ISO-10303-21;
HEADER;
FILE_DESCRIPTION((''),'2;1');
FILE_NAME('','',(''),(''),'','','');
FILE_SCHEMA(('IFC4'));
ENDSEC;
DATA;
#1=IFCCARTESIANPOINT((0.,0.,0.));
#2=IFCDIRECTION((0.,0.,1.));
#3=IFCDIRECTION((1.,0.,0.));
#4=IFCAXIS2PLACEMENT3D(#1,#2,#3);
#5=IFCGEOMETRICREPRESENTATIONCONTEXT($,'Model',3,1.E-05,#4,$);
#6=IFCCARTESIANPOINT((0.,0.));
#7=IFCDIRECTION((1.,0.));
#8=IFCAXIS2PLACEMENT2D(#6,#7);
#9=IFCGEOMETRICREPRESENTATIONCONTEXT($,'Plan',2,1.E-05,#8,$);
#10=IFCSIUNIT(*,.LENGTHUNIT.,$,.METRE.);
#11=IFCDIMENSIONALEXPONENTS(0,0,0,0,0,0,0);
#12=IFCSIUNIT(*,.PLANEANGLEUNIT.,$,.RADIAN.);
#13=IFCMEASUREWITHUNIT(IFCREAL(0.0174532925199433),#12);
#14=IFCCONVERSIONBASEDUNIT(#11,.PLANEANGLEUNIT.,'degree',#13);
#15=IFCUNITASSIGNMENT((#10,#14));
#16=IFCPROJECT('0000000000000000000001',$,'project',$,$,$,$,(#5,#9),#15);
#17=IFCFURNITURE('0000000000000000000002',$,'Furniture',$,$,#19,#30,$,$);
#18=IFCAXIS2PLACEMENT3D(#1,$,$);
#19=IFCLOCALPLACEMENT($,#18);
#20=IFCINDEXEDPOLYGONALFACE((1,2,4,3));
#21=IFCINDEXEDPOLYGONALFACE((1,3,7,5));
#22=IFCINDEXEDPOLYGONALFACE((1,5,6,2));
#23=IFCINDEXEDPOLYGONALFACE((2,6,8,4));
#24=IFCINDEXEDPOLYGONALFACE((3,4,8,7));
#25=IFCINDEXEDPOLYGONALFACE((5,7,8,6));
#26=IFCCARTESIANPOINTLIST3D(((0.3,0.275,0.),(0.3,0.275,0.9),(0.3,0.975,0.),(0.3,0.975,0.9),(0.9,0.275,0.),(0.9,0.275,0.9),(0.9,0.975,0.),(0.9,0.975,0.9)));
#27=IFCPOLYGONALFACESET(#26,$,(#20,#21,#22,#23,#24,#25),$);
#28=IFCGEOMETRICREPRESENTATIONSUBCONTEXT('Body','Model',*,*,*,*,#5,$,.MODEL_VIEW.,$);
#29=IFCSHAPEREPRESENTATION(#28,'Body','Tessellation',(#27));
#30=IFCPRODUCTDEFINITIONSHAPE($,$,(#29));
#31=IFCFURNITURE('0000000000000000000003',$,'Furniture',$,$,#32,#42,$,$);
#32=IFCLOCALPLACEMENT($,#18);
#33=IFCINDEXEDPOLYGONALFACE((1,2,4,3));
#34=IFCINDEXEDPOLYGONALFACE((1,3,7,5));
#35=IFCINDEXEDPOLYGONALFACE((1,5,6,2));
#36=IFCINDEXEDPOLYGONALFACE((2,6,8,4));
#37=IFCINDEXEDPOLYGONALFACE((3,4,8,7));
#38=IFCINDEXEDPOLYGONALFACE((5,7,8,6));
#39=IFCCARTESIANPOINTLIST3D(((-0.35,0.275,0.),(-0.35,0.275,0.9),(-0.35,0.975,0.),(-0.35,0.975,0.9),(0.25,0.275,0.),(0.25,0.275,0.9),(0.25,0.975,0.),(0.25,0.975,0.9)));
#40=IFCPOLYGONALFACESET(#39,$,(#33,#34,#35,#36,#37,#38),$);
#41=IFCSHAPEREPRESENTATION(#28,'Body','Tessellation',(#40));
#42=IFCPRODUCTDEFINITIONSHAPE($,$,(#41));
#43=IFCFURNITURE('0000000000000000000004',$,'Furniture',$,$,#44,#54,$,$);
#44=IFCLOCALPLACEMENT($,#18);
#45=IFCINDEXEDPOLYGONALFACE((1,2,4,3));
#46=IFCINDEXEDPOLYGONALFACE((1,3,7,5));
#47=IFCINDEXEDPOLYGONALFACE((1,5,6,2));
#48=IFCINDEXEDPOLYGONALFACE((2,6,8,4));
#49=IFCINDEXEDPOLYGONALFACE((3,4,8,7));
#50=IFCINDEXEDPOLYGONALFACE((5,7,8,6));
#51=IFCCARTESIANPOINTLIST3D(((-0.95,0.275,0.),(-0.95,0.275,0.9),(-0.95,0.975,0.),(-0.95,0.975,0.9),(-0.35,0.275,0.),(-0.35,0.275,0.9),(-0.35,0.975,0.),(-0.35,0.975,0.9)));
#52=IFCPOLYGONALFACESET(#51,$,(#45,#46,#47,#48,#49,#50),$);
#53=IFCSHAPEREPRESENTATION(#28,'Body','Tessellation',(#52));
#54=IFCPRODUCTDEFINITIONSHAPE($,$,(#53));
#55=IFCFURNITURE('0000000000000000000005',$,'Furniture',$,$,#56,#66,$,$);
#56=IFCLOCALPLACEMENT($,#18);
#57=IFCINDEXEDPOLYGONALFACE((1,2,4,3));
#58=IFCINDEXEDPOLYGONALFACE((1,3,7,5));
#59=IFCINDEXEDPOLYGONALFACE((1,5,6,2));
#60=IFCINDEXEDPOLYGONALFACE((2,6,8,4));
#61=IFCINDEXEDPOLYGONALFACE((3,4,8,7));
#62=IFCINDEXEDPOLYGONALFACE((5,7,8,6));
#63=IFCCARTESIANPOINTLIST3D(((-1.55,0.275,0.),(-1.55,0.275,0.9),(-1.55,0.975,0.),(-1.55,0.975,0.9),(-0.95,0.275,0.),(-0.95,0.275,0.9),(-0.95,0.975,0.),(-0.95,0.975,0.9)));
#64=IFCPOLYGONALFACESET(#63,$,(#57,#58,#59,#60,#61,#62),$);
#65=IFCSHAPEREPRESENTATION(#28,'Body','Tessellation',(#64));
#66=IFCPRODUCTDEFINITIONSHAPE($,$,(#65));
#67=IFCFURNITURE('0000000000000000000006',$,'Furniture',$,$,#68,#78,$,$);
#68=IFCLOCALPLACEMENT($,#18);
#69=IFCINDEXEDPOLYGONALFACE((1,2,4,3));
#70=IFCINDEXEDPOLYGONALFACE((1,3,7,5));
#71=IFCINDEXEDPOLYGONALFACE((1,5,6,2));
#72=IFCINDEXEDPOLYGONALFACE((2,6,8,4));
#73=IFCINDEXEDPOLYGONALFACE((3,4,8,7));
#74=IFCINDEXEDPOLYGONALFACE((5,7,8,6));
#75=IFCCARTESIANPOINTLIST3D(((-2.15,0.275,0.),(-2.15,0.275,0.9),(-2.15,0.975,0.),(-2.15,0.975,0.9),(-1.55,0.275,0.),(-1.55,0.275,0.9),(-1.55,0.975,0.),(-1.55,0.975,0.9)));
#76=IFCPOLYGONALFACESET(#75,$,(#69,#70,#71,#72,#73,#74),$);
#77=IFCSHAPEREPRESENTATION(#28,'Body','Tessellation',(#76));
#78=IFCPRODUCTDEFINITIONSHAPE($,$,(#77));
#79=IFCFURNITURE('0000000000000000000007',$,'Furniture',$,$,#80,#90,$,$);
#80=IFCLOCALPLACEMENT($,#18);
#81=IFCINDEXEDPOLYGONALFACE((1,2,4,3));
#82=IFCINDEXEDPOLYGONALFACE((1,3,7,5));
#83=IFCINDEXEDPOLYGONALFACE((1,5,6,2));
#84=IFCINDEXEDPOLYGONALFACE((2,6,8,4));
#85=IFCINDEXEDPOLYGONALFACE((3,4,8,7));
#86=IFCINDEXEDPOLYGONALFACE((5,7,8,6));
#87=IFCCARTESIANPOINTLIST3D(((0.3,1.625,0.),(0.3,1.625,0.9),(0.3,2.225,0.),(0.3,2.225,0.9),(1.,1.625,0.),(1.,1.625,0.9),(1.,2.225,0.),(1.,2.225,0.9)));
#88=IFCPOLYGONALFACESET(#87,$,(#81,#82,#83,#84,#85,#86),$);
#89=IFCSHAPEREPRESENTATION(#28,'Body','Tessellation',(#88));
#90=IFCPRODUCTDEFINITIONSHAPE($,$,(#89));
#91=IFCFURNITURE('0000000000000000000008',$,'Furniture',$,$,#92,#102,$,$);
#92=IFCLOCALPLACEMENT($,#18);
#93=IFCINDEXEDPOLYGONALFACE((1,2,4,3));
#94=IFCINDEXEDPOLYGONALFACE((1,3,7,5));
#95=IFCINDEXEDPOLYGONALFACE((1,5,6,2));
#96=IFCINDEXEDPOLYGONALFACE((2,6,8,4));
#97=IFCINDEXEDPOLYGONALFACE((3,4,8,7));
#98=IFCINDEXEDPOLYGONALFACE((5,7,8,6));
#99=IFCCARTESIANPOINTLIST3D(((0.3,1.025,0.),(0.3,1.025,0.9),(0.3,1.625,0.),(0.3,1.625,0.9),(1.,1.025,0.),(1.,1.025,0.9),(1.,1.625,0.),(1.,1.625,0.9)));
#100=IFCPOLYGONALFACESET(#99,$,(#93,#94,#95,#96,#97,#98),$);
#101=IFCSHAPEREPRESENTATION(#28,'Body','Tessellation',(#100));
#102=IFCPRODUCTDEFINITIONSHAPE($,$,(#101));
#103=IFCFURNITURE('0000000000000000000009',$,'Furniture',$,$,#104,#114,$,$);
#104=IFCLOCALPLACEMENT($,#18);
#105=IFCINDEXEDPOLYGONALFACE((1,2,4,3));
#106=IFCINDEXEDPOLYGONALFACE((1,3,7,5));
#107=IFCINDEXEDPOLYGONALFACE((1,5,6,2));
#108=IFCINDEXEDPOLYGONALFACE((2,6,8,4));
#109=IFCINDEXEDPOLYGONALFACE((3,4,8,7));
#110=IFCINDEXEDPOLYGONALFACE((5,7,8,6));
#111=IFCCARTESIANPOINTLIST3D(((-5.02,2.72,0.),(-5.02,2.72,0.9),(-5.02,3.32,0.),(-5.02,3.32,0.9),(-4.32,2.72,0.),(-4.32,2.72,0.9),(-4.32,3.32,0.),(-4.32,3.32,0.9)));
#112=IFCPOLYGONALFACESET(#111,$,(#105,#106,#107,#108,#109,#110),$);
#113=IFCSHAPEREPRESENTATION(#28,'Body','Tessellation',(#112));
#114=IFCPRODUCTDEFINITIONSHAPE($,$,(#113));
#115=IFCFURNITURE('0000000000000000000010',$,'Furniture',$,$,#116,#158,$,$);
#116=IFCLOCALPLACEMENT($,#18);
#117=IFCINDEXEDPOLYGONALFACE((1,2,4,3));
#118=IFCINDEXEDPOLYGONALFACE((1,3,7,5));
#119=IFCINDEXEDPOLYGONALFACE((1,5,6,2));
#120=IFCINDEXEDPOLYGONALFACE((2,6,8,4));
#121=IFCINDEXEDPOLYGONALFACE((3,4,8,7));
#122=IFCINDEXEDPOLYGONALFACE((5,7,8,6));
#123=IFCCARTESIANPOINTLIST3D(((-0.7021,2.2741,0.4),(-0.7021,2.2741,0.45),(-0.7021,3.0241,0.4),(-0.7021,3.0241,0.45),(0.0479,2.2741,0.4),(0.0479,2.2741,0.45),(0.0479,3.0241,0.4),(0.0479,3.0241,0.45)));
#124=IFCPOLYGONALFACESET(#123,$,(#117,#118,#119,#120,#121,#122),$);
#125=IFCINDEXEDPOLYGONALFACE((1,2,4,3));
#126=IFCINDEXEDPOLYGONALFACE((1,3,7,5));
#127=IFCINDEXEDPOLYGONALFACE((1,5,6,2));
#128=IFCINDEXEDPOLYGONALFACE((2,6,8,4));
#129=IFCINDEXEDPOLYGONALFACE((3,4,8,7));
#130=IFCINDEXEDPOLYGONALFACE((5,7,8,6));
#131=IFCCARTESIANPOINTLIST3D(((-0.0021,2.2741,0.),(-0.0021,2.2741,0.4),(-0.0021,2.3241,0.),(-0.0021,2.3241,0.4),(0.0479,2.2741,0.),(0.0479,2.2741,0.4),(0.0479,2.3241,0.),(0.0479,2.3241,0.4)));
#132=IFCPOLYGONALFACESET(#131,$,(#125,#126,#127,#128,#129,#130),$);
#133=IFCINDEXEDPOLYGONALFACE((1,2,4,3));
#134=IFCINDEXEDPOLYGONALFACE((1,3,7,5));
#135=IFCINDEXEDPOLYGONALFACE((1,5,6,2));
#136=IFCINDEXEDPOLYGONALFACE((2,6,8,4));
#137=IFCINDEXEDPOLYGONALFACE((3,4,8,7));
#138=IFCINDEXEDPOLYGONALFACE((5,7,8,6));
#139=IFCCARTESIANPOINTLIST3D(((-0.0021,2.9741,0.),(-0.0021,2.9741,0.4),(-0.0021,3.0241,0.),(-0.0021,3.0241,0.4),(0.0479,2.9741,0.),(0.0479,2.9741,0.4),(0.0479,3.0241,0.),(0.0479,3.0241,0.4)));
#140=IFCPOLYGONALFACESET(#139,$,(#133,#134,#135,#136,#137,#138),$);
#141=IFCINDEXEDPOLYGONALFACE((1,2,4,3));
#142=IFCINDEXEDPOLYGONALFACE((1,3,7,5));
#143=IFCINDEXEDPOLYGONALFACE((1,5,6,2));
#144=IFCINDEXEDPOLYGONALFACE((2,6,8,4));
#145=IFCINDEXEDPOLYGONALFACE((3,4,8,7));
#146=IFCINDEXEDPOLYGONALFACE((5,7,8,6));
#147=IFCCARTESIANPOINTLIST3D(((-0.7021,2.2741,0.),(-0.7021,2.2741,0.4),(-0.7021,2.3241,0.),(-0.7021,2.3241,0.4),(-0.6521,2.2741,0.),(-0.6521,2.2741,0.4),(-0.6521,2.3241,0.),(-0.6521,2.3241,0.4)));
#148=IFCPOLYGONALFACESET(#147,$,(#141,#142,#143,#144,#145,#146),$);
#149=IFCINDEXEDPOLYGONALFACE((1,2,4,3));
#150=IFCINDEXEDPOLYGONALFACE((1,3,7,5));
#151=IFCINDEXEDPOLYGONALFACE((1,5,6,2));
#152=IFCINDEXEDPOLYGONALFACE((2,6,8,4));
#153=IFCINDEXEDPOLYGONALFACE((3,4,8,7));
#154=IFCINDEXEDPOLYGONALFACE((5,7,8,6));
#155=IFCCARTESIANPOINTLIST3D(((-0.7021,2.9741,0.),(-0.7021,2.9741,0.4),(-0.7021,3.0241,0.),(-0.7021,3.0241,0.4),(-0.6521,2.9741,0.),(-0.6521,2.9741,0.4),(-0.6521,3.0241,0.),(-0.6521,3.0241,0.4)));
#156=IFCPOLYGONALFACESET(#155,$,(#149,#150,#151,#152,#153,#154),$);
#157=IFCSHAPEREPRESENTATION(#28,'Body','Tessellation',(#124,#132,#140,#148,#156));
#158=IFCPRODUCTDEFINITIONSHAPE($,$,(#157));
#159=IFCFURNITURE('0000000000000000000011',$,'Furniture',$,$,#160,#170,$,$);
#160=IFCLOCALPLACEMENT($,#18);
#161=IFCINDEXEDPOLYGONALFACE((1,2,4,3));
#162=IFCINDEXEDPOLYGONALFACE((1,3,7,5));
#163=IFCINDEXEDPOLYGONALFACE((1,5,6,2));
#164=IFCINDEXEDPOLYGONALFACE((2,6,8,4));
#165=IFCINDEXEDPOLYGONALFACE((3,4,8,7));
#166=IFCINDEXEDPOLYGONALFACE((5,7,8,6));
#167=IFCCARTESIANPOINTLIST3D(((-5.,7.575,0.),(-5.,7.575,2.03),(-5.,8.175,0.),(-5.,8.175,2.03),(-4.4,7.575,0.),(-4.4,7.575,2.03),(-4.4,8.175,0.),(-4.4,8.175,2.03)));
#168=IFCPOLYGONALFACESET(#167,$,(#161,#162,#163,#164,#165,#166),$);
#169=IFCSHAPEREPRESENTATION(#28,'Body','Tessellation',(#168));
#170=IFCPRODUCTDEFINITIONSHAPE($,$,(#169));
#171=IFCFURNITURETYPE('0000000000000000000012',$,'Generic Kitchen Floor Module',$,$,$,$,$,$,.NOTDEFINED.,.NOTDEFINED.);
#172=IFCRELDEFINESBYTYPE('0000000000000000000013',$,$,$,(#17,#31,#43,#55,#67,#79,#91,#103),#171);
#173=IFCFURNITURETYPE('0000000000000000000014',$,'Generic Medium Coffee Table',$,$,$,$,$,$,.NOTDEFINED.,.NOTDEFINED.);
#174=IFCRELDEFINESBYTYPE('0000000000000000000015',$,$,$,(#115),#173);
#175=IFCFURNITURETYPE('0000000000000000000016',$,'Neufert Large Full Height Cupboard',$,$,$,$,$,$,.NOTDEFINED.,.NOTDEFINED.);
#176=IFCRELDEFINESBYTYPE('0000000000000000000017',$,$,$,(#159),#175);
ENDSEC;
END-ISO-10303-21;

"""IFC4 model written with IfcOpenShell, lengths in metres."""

from ifc_helpers import new_model, entity, si_unit, converted_unit, frame, origin_with_axes, origin_2d_with_axis, place, context, subcontext, project, line, indexed_curve, outline, extrude, shape, source, transform, mapped, type_object, type_shapes, element, save


model = new_model("IFC4")

# Units and contexts
model_context = context("Model", 3, precision=1e-05, world=origin_with_axes())
plan_context = context("Plan", 2, precision=1e-05, world=origin_2d_with_axis())
body_context_1 = subcontext(model_context, "Body", "Model", "MODEL_VIEW")
body_context_2 = subcontext(plan_context, "Body", "Plan", "PLAN_VIEW")
ifc_project = project(units=[si_unit("LENGTHUNIT", "METRE"), converted_unit("PLANEANGLEUNIT", "degree", entity("IfcReal", 0.0174532925199433), si_unit("PLANEANGLEUNIT", "RADIAN"), dimensions=[0, 0, 0, 0, 0, 0, 0])], contexts=[model_context, plan_context])

# Furniture
furniture_type_1 = type_object("IfcFurnitureType", Name="Generic Kitchen Floor Module", AssemblyPlace="NOTDEFINED", PredefinedType="NOTDEFINED")
shared_shape_1 = source(origin_with_axes(), body_context_1, "Body", "SweptSolid", [
    extrude(outline(indexed_curve([(0.0, 0.0), (0.6, 0.0), (0.6, 0.7), (0.0, 0.7)], segments=[line(1, 2, 3, 4, 1)])), origin_with_axes(), (0.0, 0.0, 1.0), 0.9),
])
shared_shape_2 = source(origin_with_axes(), body_context_2, "Body", "Curve2D", [
    entity("IfcIndexedPolyCurve", entity("IfcCartesianPointList2D", [[0.0, 0.0], [0.6, 0.0], [0.6, 0.7], [0.0, 0.7]]), [entity("IfcLineIndex", [1, 2, 3, 4, 1])]),
])
type_shapes(furniture_type_1, [shared_shape_1, shared_shape_2])
for number, where, z_axis, x_axis, name in (
    (1, (0.9, 0.975, 0.0), (0.0, 0.0, 1.0), (-1.0, 0.0, 0.0), "Furniture"),
    (2, (0.25, 0.975, 0.0), (0.0, 0.0, 1.0), (-1.0, 0.0, 0.0), "Furniture"),
    (3, (-0.35, 0.975, 0.0), (0.0, 0.0, 1.0), (-1.0, 0.0, 0.0), "Furniture"),
    (4, (-0.95, 0.975, 0.0), (0.0, 0.0, 1.0), (-1.0, 0.0, 0.0), "Furniture"),
    (5, (-1.55, 0.975, 0.0), (0.0, 0.0, 1.0), (-1.0, 0.0, 0.0), "Furniture"),
    (6, (0.3, 2.225, 0.0), (0.0, 0.0, 1.0), (0.0, -1.0, 0.0), "Furniture"),
    (7, (0.3, 1.625, 0.0), (0.0, 0.0, 1.0), (0.0, -1.0, 0.0), "Furniture"),
    (8, (-4.32, 2.72, 0.0), (0.0, 0.0, 1.0), (0.0, 1.0, 0.0), "Furniture"),
):
    element("IfcFurniture", number, at=place(None, frame(where, z_axis=z_axis, x_axis=x_axis)), type_object=furniture_type_1, Name=name, shapes=[
        shape(body_context_1, "Body", "MappedRepresentation", [mapped(shared_shape_1, transform((0.0, 0.0, 0.0), x_axis=(1.0, 0.0, 0.0), y_axis=(0.0, 1.0, 0.0), z_axis=(0.0, 0.0, 1.0), scale=1.0))]),
        shape(body_context_2, "Body", "MappedRepresentation", [mapped(shared_shape_2, transform((0.0, 0.0, 0.0), x_axis=(1.0, 0.0, 0.0), y_axis=(0.0, 1.0, 0.0), z_axis=(0.0, 0.0, 1.0), scale=1.0))]),
    ])
furniture_type_2 = type_object("IfcFurnitureType", Name="Generic Medium Coffee Table", AssemblyPlace="NOTDEFINED", PredefinedType="NOTDEFINED")
shared_shape_3 = source(origin_with_axes(), body_context_1, "Body", "SweptSolid", [
    extrude(outline(indexed_curve([(0.0, 0.0), (0.75, 0.0), (0.75, 0.75), (0.0, 0.75)], segments=[line(1, 2, 3, 4, 1)])), frame((-0.375, -0.375, 0.4), z_axis=(0.0, 0.0, 1.0), x_axis=(1.0, 0.0, 0.0)), (0.0, 0.0, 1.0), 0.05),
    extrude(outline(indexed_curve([(0.0, 0.0), (0.05, 0.0), (0.05, 0.05), (0.0, 0.05)], segments=[line(1, 2, 3, 4, 1)])), frame((-0.375, -0.375, 0.0), z_axis=(0.0, 0.0, 1.0), x_axis=(1.0, 0.0, 0.0)), (0.0, 0.0, 1.0), 0.4),
    extrude(outline(indexed_curve([(0.75, 0.0), (0.7, 0.0), (0.7, 0.05), (0.75, 0.05)], segments=[line(1, 2, 3, 4, 1)])), frame((-0.375, -0.375, 0.0), z_axis=(0.0, 0.0, 1.0), x_axis=(1.0, 0.0, 0.0)), (0.0, 0.0, 1.0), 0.4),
    extrude(outline(indexed_curve([(0.0, 0.75), (0.05, 0.75), (0.05, 0.7), (0.0, 0.7)], segments=[line(1, 2, 3, 4, 1)])), frame((-0.375, -0.375, 0.0), z_axis=(0.0, 0.0, 1.0), x_axis=(1.0, 0.0, 0.0)), (0.0, 0.0, 1.0), 0.4),
    extrude(outline(indexed_curve([(0.75, 0.75), (0.7, 0.75), (0.7, 0.7), (0.75, 0.7)], segments=[line(1, 2, 3, 4, 1)])), frame((-0.375, -0.375, 0.0), z_axis=(0.0, 0.0, 1.0), x_axis=(1.0, 0.0, 0.0)), (0.0, 0.0, 1.0), 0.4),
])
shared_shape_4 = source(origin_with_axes(), body_context_2, "Body", "Curve2D", [
    entity("IfcIndexedPolyCurve", entity("IfcCartesianPointList2D", [[-0.375, -0.375], [0.375, -0.375], [0.375, 0.375], [-0.375, 0.375]]), [entity("IfcLineIndex", [1, 2, 3, 4, 1])]),
])
type_shapes(furniture_type_2, [shared_shape_3, shared_shape_4])
furniture_1_placement = place(None, frame((-0.3271, 2.6491, 0.0), z_axis=(0.0, 0.0, 1.0), x_axis=(0.0, 1.0, 0.0)))
element("IfcFurniture", 9, at=furniture_1_placement, type_object=furniture_type_2, Name="Furniture", shapes=[
    shape(body_context_1, "Body", "MappedRepresentation", [mapped(shared_shape_3, transform((0.0, 0.0, 0.0), x_axis=(1.0, 0.0, 0.0), y_axis=(0.0, 1.0, 0.0), z_axis=(0.0, 0.0, 1.0), scale=1.0))]),
    shape(body_context_2, "Body", "MappedRepresentation", [mapped(shared_shape_4, transform((0.0, 0.0, 0.0), x_axis=(1.0, 0.0, 0.0), y_axis=(0.0, 1.0, 0.0), z_axis=(0.0, 0.0, 1.0), scale=1.0))]),
])
furniture_type_3 = type_object("IfcFurnitureType", Name="Neufert Large Full Height Cupboard", AssemblyPlace="NOTDEFINED", PredefinedType="NOTDEFINED")
shared_shape_5 = source(origin_with_axes(), body_context_1, "Body", "SweptSolid", [
    extrude(outline(indexed_curve([(0.0, 0.0), (0.6, 0.0), (0.6, 0.6), (0.0, 0.6)], segments=[line(1, 2, 3, 4, 1)])), origin_with_axes(), (0.0, 0.0, 1.0), 2.03),
])
shared_shape_6 = source(origin_with_axes(), body_context_2, "Body", "Curve2D", [
    entity("IfcIndexedPolyCurve", entity("IfcCartesianPointList2D", [[0.0, 0.0], [0.6, 0.0], [0.6, 0.6], [0.0, 0.6]]), [entity("IfcLineIndex", [1, 2, 3, 4, 1])]),
])
type_shapes(furniture_type_3, [shared_shape_5, shared_shape_6])
furniture_2_placement = place(None, frame((-5.0, 7.575, 0.0), z_axis=(0.0, 0.0, 1.0), x_axis=(1.0, 0.0, 0.0)))
element("IfcFurniture", 10, at=furniture_2_placement, type_object=furniture_type_3, Name="Furniture", shapes=[
    shape(body_context_1, "Body", "MappedRepresentation", [mapped(shared_shape_5, transform((0.0, 0.0, 0.0), x_axis=(1.0, 0.0, 0.0), y_axis=(0.0, 1.0, 0.0), z_axis=(0.0, 0.0, 1.0), scale=1.0))]),
    shape(body_context_2, "Body", "MappedRepresentation", [mapped(shared_shape_6, transform((0.0, 0.0, 0.0), x_axis=(1.0, 0.0, 0.0), y_axis=(0.0, 1.0, 0.0), z_axis=(0.0, 0.0, 1.0), scale=1.0))]),
])

save(model, "model.ifc")
